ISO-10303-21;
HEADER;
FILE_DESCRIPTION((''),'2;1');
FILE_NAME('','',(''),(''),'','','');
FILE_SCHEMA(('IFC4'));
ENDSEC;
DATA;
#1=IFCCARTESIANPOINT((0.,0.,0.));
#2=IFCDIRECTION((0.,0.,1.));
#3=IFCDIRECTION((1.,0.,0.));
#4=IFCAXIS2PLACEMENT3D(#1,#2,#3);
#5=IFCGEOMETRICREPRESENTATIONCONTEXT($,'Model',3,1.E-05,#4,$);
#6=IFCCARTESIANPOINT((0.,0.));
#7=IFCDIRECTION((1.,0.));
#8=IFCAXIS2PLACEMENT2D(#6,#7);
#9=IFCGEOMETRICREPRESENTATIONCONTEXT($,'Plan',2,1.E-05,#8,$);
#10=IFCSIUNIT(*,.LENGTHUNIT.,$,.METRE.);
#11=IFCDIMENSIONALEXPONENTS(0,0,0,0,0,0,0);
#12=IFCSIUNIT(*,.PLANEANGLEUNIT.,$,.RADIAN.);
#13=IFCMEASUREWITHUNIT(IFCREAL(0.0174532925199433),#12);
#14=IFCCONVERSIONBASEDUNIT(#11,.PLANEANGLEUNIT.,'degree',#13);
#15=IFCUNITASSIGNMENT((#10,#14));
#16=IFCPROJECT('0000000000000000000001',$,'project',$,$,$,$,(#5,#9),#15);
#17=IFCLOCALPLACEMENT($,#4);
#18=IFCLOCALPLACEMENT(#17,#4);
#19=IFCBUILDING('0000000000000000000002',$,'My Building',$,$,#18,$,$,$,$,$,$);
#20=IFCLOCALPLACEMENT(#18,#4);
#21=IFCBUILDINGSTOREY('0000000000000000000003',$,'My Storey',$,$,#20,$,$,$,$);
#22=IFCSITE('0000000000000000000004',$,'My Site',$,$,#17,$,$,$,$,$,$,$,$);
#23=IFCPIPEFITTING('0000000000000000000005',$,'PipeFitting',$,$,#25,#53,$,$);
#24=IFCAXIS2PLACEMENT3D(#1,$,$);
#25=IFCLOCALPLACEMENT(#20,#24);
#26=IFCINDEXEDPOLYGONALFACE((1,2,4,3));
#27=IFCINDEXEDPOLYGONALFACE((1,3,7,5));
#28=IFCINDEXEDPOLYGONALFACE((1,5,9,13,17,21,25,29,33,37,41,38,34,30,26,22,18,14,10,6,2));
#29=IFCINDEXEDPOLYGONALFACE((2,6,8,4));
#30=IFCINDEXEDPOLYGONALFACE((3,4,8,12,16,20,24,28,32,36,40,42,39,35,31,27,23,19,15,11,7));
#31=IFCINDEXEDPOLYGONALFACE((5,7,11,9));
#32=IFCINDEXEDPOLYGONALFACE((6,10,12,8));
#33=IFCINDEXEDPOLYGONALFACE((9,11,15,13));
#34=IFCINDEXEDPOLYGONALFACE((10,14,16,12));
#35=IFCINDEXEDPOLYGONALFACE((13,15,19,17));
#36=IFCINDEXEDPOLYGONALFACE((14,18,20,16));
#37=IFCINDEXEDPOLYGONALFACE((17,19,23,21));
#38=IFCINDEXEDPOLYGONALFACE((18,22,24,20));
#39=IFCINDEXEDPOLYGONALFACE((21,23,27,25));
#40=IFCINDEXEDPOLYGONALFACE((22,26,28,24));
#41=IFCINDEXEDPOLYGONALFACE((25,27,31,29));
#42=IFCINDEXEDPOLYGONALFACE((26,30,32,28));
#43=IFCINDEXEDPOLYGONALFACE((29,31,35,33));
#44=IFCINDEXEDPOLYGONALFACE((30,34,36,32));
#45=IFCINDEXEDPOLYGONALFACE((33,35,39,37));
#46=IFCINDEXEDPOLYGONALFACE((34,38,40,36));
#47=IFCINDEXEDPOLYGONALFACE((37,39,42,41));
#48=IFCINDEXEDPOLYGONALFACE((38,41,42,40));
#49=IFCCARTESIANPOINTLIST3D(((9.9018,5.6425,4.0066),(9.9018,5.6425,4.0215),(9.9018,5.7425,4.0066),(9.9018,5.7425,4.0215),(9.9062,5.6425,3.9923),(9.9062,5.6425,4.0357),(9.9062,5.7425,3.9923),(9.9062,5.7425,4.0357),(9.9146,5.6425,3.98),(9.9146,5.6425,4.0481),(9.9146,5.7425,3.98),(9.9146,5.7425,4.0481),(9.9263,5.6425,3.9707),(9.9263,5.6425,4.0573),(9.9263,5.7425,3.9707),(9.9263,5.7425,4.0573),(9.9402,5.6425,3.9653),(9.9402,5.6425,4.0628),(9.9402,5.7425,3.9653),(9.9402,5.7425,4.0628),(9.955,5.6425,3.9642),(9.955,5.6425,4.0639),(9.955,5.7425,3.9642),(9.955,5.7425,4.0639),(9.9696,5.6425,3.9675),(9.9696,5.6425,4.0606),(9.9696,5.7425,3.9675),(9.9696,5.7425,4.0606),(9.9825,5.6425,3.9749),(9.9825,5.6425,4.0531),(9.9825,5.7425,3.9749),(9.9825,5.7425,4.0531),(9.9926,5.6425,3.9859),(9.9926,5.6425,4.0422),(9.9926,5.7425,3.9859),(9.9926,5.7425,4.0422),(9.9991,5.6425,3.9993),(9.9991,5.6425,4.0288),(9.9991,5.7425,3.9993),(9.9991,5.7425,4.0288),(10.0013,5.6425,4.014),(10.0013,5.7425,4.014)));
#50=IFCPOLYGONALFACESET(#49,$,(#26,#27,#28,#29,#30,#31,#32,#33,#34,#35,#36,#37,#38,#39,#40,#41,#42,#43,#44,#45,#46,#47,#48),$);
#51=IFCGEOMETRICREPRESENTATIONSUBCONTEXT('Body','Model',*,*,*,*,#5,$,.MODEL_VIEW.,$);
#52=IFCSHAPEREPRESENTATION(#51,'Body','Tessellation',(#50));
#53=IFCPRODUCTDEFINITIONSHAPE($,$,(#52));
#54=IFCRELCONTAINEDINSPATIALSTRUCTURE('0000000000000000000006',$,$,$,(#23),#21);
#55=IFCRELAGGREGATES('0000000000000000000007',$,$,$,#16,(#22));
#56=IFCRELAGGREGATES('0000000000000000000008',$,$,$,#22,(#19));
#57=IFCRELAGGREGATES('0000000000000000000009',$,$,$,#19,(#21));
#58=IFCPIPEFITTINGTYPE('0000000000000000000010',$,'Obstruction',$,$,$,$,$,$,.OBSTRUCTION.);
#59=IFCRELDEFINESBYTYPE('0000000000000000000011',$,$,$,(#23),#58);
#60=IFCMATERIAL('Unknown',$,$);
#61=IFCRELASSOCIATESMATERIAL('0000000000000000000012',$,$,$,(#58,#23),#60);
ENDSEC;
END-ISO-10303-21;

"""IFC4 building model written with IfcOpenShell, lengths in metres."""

from ifc_helpers import new_model, entity, si_unit, converted_unit, frame, origin_with_axes, origin_2d_with_axis, place, context, subcontext, project, spatial, circle, extrude, material, material_profile, profile_set, profile_usage, type_object, element, save


model = new_model("IFC4")

# Units and contexts
model_context = context("Model", 3, precision=1e-05, world=origin_with_axes())
plan_context = context("Plan", 2, precision=1e-05, world=origin_2d_with_axis())
body_context_1 = subcontext(model_context, "Body", "Model", "MODEL_VIEW")
ifc_project = project(units=[si_unit("LENGTHUNIT", "METRE"), converted_unit("PLANEANGLEUNIT", "degree", entity("IfcReal", 0.0174532925199433), si_unit("PLANEANGLEUNIT", "RADIAN"), dimensions=[0, 0, 0, 0, 0, 0, 0])], contexts=[model_context, plan_context])

# Site, building, storey
site_placement = place(None, origin_with_axes())
site = spatial("IfcSite", under=ifc_project, at=site_placement, Name="My Site")
building_placement = place(site_placement, origin_with_axes())
building = spatial("IfcBuilding", under=site, at=building_placement, Name="My Building")
storey_placement = place(building_placement, origin_with_axes())
storey = spatial("IfcBuildingStorey", under=building, at=storey_placement, Name="My Storey")

# Shared definitions
ifc_material = material(Name="Unknown")

# Pipe fitting
ifc_material_profile_1 = material_profile(ifc_material, circle(Radius=0.05))
ifc_profile_set_1 = profile_set([ifc_material_profile_1])
pipe_fitting_type_1 = type_object("IfcPipeFittingType", Name="Obstruction", PredefinedType="OBSTRUCTION", material=ifc_profile_set_1)
ifc_profile_usage_1 = profile_usage(ifc_profile_set_1, cardinal=5)
pipe_fitting_1_placement = place(storey_placement, frame((9.9513, 5.7425, 4.014), z_axis=(0.0, -1.0, 0.0), x_axis=(1.0, 0.0, 0.0)))
element("IfcPipeFitting", 1, at=pipe_fitting_1_placement, inside=storey, type_object=pipe_fitting_type_1, material=ifc_profile_usage_1, Name="PipeFitting", context=body_context_1, shape_type="SweptSolid", body=[
    extrude(circle(Radius=0.05), origin_with_axes(), (0.0, 0.0, 1.0), 0.1),
])

save(model, "model.ifc")
